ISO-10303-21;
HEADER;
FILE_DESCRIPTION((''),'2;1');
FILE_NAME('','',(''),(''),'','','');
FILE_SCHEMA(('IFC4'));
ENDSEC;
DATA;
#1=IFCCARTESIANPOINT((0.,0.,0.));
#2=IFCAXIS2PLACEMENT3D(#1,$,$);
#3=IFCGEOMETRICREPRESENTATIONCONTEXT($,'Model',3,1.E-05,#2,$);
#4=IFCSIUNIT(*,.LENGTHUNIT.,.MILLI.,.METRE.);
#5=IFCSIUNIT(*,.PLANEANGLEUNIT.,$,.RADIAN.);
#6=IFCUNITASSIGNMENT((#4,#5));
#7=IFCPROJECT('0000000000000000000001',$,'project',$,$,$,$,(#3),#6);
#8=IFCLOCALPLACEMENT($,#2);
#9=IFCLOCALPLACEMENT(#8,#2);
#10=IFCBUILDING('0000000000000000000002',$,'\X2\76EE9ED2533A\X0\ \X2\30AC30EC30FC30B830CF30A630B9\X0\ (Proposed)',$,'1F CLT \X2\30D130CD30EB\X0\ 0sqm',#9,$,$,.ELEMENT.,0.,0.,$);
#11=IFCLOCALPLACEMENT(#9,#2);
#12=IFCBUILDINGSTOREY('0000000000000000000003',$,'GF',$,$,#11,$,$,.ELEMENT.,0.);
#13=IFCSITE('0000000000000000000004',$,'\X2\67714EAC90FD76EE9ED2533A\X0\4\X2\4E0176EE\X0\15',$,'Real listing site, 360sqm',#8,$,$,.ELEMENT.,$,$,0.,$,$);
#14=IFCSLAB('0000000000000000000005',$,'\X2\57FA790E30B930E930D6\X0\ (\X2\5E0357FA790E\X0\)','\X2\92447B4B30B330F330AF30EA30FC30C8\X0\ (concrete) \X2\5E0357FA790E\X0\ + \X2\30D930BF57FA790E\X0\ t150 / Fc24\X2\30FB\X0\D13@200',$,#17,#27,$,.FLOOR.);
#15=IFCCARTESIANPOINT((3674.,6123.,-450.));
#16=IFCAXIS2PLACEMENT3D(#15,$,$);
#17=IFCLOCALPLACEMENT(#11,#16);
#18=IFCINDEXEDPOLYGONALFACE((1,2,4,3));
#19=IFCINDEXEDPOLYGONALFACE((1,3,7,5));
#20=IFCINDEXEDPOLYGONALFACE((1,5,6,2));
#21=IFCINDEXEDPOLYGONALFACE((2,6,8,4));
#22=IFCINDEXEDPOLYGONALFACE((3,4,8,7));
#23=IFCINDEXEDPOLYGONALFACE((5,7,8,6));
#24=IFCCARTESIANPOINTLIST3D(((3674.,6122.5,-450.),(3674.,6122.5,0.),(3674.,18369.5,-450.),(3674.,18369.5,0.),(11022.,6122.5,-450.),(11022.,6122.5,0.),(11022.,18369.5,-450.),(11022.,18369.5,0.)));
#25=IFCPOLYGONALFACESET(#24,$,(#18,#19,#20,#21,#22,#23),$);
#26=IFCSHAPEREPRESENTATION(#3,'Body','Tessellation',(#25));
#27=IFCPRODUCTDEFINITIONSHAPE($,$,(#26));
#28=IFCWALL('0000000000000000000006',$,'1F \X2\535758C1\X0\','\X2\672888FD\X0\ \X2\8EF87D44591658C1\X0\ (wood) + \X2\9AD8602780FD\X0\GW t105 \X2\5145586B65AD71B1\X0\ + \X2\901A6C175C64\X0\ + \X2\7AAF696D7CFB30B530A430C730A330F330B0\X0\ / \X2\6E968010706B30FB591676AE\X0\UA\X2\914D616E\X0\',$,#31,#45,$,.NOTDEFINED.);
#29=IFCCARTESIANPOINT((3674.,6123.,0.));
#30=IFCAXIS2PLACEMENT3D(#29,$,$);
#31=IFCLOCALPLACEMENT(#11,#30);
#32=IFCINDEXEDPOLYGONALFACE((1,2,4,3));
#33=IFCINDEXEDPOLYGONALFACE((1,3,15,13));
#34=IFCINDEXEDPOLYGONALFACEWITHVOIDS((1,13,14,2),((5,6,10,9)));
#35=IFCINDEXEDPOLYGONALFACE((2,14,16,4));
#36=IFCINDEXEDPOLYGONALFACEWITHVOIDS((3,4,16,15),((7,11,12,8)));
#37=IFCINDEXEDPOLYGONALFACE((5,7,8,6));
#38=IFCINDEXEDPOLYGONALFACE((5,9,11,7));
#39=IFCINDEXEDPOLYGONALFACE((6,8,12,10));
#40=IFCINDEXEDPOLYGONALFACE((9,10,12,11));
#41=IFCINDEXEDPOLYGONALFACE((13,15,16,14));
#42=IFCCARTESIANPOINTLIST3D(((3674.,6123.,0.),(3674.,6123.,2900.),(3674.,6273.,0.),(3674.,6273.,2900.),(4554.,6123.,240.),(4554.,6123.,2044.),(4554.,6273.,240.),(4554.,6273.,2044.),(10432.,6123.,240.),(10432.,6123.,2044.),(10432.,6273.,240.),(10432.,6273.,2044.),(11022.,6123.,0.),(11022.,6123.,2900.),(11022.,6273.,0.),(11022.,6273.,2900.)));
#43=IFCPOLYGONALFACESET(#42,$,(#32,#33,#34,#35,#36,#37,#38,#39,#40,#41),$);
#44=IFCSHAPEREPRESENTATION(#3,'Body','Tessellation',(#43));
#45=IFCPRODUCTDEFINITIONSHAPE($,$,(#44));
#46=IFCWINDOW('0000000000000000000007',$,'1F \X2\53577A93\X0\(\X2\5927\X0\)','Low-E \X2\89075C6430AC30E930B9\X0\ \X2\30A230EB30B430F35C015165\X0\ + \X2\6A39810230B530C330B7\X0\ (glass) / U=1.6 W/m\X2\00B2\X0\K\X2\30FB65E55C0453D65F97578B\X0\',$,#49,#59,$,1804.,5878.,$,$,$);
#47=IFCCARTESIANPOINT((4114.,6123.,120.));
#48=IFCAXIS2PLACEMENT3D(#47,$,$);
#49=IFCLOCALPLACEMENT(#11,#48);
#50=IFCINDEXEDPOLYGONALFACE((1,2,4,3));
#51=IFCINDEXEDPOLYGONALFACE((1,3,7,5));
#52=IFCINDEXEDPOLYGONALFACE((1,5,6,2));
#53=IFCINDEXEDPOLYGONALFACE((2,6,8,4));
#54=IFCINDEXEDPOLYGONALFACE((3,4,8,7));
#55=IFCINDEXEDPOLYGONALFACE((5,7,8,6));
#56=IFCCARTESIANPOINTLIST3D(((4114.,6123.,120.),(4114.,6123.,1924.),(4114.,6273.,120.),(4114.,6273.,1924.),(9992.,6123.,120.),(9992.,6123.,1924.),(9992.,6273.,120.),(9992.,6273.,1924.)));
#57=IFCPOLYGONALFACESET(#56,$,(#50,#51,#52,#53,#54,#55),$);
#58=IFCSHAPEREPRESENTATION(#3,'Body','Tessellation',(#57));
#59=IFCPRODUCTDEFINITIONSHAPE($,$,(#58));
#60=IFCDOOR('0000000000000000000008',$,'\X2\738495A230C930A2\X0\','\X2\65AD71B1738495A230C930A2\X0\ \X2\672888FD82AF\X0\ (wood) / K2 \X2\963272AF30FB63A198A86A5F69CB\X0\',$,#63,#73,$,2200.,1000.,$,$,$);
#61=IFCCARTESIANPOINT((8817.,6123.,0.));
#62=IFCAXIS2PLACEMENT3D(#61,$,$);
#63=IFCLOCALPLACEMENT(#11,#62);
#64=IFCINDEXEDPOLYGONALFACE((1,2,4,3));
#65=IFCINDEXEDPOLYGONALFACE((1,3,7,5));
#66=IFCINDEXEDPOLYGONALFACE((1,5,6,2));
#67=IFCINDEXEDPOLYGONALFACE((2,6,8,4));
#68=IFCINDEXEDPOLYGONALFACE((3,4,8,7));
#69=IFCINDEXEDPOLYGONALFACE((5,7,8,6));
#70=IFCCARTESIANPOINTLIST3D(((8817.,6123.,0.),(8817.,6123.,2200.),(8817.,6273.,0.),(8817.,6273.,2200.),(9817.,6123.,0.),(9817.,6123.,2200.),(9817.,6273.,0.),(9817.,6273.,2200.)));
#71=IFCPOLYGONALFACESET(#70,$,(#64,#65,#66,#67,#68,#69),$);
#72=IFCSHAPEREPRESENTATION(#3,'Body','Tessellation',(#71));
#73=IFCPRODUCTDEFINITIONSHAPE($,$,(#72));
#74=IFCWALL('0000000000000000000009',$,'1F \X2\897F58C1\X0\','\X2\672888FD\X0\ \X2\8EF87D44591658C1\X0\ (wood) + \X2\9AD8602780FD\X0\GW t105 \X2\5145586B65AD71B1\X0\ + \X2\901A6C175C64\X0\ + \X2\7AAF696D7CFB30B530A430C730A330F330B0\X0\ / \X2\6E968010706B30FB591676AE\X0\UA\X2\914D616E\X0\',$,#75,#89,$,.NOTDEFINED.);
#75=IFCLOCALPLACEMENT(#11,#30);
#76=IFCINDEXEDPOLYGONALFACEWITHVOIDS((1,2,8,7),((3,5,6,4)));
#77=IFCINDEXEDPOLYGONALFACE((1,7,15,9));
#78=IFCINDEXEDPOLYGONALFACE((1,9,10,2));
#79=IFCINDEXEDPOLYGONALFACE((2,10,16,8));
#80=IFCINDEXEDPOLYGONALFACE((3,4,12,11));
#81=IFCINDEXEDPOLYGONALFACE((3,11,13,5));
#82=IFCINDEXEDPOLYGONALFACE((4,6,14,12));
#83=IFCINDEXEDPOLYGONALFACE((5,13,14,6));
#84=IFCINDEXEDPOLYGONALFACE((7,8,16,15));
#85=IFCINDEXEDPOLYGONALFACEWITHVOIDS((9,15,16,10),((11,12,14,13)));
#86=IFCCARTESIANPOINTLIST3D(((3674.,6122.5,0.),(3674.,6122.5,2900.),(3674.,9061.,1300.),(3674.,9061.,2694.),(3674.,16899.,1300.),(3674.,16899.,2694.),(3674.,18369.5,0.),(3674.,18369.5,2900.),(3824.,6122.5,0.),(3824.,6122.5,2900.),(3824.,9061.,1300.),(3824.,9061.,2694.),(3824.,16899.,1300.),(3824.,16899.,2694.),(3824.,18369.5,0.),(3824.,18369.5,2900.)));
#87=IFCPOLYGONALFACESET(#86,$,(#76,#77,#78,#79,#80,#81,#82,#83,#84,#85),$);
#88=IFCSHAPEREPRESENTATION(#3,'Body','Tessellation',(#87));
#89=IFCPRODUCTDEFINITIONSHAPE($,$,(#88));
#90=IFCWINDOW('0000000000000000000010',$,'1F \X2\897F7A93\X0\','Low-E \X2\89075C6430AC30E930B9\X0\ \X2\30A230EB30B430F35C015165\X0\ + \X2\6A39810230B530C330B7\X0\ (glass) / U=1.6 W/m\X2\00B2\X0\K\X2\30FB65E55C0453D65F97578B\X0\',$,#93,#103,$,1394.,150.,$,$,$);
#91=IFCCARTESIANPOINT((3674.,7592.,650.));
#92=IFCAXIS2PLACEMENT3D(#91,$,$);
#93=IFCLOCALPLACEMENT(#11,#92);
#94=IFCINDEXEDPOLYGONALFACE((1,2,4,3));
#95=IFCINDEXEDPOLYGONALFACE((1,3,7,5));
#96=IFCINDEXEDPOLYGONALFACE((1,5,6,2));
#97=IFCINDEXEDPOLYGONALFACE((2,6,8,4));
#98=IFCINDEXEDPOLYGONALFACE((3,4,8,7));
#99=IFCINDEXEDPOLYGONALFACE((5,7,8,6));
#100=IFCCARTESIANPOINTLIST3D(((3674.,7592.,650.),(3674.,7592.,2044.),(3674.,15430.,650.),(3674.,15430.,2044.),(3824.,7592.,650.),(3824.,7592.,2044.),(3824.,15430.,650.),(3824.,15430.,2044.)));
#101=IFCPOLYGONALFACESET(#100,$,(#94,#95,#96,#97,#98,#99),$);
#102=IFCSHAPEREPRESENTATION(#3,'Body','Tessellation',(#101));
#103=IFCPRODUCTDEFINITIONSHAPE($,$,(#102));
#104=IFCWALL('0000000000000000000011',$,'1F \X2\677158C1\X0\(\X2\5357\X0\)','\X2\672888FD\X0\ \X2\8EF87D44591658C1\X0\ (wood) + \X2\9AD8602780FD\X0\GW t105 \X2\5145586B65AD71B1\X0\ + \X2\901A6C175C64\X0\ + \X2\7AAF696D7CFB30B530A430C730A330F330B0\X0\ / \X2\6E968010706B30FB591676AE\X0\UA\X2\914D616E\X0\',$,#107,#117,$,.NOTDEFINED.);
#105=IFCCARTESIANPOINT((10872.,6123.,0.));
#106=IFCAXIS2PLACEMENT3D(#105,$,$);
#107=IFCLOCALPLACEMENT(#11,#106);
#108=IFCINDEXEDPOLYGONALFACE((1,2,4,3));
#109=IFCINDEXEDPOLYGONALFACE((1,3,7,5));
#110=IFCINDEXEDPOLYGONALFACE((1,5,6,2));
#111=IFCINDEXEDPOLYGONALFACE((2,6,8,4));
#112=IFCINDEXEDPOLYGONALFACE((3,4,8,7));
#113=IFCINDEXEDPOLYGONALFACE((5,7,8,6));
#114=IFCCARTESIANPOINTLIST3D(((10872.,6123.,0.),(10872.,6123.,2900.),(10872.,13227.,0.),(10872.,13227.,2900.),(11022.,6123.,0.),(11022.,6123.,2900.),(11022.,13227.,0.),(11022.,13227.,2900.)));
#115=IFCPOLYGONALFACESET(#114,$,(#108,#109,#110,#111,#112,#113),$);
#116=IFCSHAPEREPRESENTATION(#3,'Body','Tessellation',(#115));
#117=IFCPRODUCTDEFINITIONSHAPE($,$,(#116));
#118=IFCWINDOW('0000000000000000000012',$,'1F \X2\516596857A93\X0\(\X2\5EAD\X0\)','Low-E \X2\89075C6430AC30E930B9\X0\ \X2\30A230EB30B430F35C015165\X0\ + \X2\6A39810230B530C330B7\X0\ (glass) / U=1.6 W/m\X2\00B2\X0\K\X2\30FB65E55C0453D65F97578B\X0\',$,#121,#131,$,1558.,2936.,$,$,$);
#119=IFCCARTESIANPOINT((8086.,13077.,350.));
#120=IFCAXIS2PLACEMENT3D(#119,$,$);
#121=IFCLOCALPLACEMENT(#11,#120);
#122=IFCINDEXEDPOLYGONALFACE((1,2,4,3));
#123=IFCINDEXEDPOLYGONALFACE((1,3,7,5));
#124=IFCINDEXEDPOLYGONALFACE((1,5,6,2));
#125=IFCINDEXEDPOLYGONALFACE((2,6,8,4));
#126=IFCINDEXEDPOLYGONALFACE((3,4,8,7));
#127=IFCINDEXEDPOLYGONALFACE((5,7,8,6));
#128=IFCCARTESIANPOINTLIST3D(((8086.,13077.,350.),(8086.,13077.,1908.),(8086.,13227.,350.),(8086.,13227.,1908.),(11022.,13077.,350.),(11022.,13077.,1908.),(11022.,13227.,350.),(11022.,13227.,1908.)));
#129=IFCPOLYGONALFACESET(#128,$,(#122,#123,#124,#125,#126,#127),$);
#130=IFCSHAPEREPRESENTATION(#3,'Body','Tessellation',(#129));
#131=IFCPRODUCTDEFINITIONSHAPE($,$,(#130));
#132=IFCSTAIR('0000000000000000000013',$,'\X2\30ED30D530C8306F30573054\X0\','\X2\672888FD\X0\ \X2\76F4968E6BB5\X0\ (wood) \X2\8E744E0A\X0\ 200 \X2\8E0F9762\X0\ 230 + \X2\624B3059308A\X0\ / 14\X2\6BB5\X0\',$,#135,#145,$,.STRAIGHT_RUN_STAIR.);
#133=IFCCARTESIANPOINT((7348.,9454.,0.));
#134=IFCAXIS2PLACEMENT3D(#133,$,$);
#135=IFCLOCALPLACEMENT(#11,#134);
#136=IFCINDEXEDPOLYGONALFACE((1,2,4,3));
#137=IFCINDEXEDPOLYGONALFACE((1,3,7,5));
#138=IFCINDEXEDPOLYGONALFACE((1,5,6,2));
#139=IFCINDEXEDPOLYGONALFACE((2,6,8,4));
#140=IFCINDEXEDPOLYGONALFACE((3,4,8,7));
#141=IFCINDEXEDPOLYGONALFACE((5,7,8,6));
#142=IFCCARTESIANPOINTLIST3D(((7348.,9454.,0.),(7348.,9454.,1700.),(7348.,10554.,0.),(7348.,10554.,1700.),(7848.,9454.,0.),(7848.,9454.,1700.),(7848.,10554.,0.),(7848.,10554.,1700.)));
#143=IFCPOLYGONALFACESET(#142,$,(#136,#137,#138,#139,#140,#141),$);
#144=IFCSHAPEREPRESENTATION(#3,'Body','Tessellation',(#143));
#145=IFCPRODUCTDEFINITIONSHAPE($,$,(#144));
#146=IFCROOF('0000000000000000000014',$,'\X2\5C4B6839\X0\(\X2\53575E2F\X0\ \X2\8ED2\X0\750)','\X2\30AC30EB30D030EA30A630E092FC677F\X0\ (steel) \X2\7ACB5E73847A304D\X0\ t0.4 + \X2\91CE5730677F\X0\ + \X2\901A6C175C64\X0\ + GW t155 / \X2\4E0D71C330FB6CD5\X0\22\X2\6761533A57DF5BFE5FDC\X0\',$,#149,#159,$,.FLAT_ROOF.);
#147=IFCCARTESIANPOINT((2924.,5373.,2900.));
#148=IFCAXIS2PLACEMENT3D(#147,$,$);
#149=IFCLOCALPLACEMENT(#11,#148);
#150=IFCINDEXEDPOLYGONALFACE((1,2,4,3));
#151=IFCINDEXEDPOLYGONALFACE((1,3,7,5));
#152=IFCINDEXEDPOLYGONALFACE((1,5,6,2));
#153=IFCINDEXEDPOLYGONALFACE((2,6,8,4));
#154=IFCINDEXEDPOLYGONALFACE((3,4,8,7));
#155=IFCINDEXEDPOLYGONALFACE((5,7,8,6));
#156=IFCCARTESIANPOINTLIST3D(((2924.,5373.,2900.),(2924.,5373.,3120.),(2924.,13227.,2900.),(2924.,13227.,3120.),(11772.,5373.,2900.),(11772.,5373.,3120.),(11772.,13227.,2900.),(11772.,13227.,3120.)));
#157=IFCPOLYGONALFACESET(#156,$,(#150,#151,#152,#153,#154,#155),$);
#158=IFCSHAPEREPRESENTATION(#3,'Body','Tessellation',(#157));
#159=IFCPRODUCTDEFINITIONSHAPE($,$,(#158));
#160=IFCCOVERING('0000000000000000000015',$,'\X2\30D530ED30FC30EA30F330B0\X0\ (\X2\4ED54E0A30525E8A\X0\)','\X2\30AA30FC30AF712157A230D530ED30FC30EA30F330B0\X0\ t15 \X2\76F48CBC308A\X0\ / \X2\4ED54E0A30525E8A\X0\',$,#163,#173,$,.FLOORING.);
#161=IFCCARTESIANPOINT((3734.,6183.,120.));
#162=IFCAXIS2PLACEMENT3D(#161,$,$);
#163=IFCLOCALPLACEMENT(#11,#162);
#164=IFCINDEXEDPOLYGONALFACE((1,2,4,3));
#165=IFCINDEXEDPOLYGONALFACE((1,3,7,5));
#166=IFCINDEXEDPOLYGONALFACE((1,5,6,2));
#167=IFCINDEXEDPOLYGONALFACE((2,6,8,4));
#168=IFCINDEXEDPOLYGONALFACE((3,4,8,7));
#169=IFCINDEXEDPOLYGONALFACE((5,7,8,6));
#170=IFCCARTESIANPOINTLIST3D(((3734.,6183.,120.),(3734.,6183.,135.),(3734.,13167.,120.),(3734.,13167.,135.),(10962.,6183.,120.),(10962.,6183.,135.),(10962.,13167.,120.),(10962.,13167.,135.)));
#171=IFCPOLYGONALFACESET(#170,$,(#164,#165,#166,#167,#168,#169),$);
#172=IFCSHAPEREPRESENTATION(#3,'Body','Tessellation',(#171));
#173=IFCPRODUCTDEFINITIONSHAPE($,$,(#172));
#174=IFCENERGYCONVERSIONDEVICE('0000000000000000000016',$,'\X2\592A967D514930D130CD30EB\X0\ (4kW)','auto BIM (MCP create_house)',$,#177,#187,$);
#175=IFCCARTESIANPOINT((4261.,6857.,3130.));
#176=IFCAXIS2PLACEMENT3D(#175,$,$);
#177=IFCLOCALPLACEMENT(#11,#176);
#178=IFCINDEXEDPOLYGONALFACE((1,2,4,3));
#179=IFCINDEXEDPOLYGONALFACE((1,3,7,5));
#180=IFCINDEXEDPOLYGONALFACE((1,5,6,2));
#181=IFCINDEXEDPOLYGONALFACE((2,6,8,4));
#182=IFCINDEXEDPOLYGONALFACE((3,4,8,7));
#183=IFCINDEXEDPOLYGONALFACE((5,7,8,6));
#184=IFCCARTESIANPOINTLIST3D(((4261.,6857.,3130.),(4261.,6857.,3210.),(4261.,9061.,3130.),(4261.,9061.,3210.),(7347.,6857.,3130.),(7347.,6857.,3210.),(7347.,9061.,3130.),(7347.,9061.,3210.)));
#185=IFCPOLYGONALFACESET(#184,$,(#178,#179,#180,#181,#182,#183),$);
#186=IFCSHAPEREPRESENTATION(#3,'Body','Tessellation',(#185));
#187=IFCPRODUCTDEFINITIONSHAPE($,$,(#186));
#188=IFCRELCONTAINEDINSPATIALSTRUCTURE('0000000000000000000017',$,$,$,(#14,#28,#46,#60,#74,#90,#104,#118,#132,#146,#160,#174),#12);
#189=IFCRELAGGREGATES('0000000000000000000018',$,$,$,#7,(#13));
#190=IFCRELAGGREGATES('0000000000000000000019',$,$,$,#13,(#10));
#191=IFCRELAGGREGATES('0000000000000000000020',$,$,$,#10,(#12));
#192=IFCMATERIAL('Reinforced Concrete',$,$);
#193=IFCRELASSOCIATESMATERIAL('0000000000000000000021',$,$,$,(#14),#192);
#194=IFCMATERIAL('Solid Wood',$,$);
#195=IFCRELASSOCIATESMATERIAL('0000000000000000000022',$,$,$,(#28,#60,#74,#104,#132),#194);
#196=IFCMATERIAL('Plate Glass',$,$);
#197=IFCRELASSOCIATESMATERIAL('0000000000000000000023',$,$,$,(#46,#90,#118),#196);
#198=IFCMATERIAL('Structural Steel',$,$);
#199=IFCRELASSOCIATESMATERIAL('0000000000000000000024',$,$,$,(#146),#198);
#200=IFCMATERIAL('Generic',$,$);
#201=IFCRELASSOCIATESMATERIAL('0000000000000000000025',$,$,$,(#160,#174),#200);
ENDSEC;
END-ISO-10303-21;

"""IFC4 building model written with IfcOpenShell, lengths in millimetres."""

from ifc_helpers import new_model, si_unit, frame, frame_2d, origin, place, context, project, spatial, rectangle, extrude, material, element, fill, save


model = new_model("IFC4")

# Units and contexts
model_context = context("Model", 3, precision=1e-05, world=origin())
ifc_project = project(units=[si_unit("LENGTHUNIT", "METRE", prefix="MILLI"), si_unit("PLANEANGLEUNIT", "RADIAN")], contexts=[model_context])

# Site, building, storey
site_placement = place(None, origin())
site = spatial("IfcSite", under=ifc_project, at=site_placement, Name="東京都目黒区4丁目15", ObjectType="Real listing site, 360sqm", CompositionType="ELEMENT", RefElevation=0.0)
building_placement = place(site_placement, origin())
building = spatial("IfcBuilding", under=site, at=building_placement, Name="目黒区 ガレージハウス (Proposed)", ObjectType="1F CLT パネル 0sqm", CompositionType="ELEMENT", ElevationOfRefHeight=0.0, ElevationOfTerrain=0.0)
storey_placement = place(building_placement, origin())
storey = spatial("IfcBuildingStorey", under=building, at=storey_placement, Name="GF", CompositionType="ELEMENT", Elevation=0.0)

# Slab
ifc_material_1 = material(Name="Reinforced Concrete")
slab_1_placement = place(storey_placement, frame((3674.0, 6123.0, -450.0)))
element("IfcSlab", 1, at=slab_1_placement, inside=storey, material=ifc_material_1, Name="基礎スラブ (布基礎)", Description="鉄筋コンクリート (concrete) 布基礎 + ベタ基礎 t150 / Fc24・D13@200", PredefinedType="FLOOR", context=model_context, shape_type="SweptSolid", body=[
    extrude(rectangle(XDim=7348.0, YDim=12247.0, at=frame_2d((3674.0, 6123.0))), frame((3674.0, 6123.0, -450.0)), (0.0, 0.0, 1.0), 450.0),
])
ifc_material_2 = material(Name="Solid Wood")

# Wall, openings, window, door
wall_1_placement = place(storey_placement, frame((3674.0, 6123.0, 0.0)))
wall_1 = element("IfcWall", 2, at=wall_1_placement, inside=storey, material=ifc_material_2, Name="1F 南壁", Description="木製 軸組外壁 (wood) + 高性能GW t105 充填断熱 + 通気層 + 窯業系サイディング / 準耐火・外皮UA配慮", PredefinedType="NOTDEFINED", context=model_context, shape_type="SweptSolid", body=[
    extrude(rectangle(XDim=7348.0, YDim=150.0, at=frame_2d((3674.0, 75.0))), frame((3674.0, 6123.0, 0.0)), (0.0, 0.0, 1.0), 2900.0),
])
opening_1_placement = place(storey_placement, frame((4114.0, 6123.0, 120.0)))
opening_1 = element("IfcOpeningElement", 3, at=opening_1_placement, cuts=wall_1, PredefinedType="NOTDEFINED", context=model_context, shape_type="SweptSolid", body=[
    extrude(rectangle(XDim=5878.0, YDim=150.0, at=frame_2d((2939.0, 75.0))), frame((4114.0, 6123.0, 120.0)), (0.0, 0.0, 1.0), 1804.0),
])
opening_2_placement = place(storey_placement, frame((8817.0, 6123.0, 0.0)))
opening_2 = element("IfcOpeningElement", 4, at=opening_2_placement, cuts=wall_1, PredefinedType="NOTDEFINED", context=model_context, shape_type="SweptSolid", body=[
    extrude(rectangle(XDim=1000.0, YDim=150.0, at=frame_2d((500.0, 75.0))), frame((8817.0, 6123.0, 0.0)), (0.0, 0.0, 1.0), 2200.0),
])
ifc_material_3 = material(Name="Plate Glass")
window_1_placement = place(storey_placement, frame((4114.0, 6123.0, 120.0)))
window_1 = element("IfcWindow", 5, at=window_1_placement, inside=storey, material=ifc_material_3, Name="1F 南窓(大)", Description="Low-E 複層ガラス アルゴン封入 + 樹脂サッシ (glass) / U=1.6 W/m²K・日射取得型", OverallHeight=1804.0, OverallWidth=5878.0, context=model_context, shape_type="SweptSolid", body=[
    extrude(rectangle(XDim=5878.0, YDim=150.0, at=frame_2d((2939.0, 75.0))), frame((4114.0, 6123.0, 120.0)), (0.0, 0.0, 1.0), 1804.0),
])
fill(opening_1, window_1)
door_1_placement = place(storey_placement, frame((8817.0, 6123.0, 0.0)))
door_1 = element("IfcDoor", 6, at=door_1_placement, inside=storey, material=ifc_material_2, Name="玄関ドア", Description="断熱玄関ドア 木製芯 (wood) / K2 防犯・採風機構", OverallHeight=2200.0, OverallWidth=1000.0, context=model_context, shape_type="SweptSolid", body=[
    extrude(rectangle(XDim=1000.0, YDim=150.0, at=frame_2d((500.0, 75.0))), frame((8817.0, 6123.0, 0.0)), (0.0, 0.0, 1.0), 2200.0),
])
fill(opening_2, door_1)

# Walls, openings, windows
wall_2_placement = place(storey_placement, frame((3674.0, 6123.0, 0.0)))
wall_2 = element("IfcWall", 7, at=wall_2_placement, inside=storey, material=ifc_material_2, Name="1F 西壁", Description="木製 軸組外壁 (wood) + 高性能GW t105 充填断熱 + 通気層 + 窯業系サイディング / 準耐火・外皮UA配慮", PredefinedType="NOTDEFINED", context=model_context, shape_type="SweptSolid", body=[
    extrude(rectangle(XDim=150.0, YDim=12247.0, at=frame_2d((75.0, 6123.0))), frame((3674.0, 6123.0, 0.0)), (0.0, 0.0, 1.0), 2900.0),
])
opening_3_placement = place(storey_placement, frame((3674.0, 7592.0, 650.0)))
opening_3 = element("IfcOpeningElement", 8, at=opening_3_placement, cuts=wall_2, PredefinedType="NOTDEFINED", context=model_context, shape_type="SweptSolid", body=[
    extrude(rectangle(XDim=150.0, YDim=7838.0, at=frame_2d((75.0, 3919.0))), frame((3674.0, 7592.0, 650.0)), (0.0, 0.0, 1.0), 1394.0),
])
window_2_placement = place(storey_placement, frame((3674.0, 7592.0, 650.0)))
window_2 = element("IfcWindow", 9, at=window_2_placement, inside=storey, material=ifc_material_3, Name="1F 西窓", Description="Low-E 複層ガラス アルゴン封入 + 樹脂サッシ (glass) / U=1.6 W/m²K・日射取得型", OverallHeight=1394.0, OverallWidth=150.0, context=model_context, shape_type="SweptSolid", body=[
    extrude(rectangle(XDim=150.0, YDim=7838.0, at=frame_2d((75.0, 3919.0))), frame((3674.0, 7592.0, 650.0)), (0.0, 0.0, 1.0), 1394.0),
])
fill(opening_3, window_2)
wall_3_placement = place(storey_placement, frame((10872.0, 6123.0, 0.0)))
wall_3 = element("IfcWall", 10, at=wall_3_placement, inside=storey, material=ifc_material_2, Name="1F 東壁(南)", Description="木製 軸組外壁 (wood) + 高性能GW t105 充填断熱 + 通気層 + 窯業系サイディング / 準耐火・外皮UA配慮", PredefinedType="NOTDEFINED", context=model_context, shape_type="SweptSolid", body=[
    extrude(rectangle(XDim=150.0, YDim=7104.0, at=frame_2d((75.0, 3552.0))), frame((10872.0, 6123.0, 0.0)), (0.0, 0.0, 1.0), 2900.0),
])
opening_4_placement = place(storey_placement, frame((8086.0, 13077.0, 350.0)))
opening_4 = element("IfcOpeningElement", 11, at=opening_4_placement, cuts=wall_3, PredefinedType="NOTDEFINED", context=model_context, shape_type="SweptSolid", body=[
    extrude(rectangle(XDim=2936.0, YDim=150.0, at=frame_2d((1468.0, 75.0))), frame((8086.0, 13077.0, 350.0)), (0.0, 0.0, 1.0), 1558.0),
])
window_3_placement = place(storey_placement, frame((8086.0, 13077.0, 350.0)))
window_3 = element("IfcWindow", 12, at=window_3_placement, inside=storey, material=ifc_material_3, Name="1F 入隅窓(庭)", Description="Low-E 複層ガラス アルゴン封入 + 樹脂サッシ (glass) / U=1.6 W/m²K・日射取得型", OverallHeight=1558.0, OverallWidth=2936.0, context=model_context, shape_type="SweptSolid", body=[
    extrude(rectangle(XDim=2936.0, YDim=150.0, at=frame_2d((1468.0, 75.0))), frame((8086.0, 13077.0, 350.0)), (0.0, 0.0, 1.0), 1558.0),
])
fill(opening_4, window_3)

# Stair
stair_placement = place(storey_placement, frame((7348.0, 9454.0, 0.0)))
element("IfcStair", 13, at=stair_placement, inside=storey, material=ifc_material_2, Name="ロフトはしご", Description="木製 直階段 (wood) 蹴上 200 踏面 230 + 手すり / 14段", PredefinedType="STRAIGHT_RUN_STAIR", context=model_context, shape_type="SweptSolid", body=[
    extrude(rectangle(XDim=500.0, YDim=1100.0, at=frame_2d((250.0, 550.0))), frame((7348.0, 9454.0, 0.0)), (0.0, 0.0, 1.0), 1700.0),
])

# Roof
ifc_material_4 = material(Name="Structural Steel")
roof_placement = place(storey_placement, frame((2924.0, 5373.0, 2900.0)))
element("IfcRoof", 14, at=roof_placement, inside=storey, material=ifc_material_4, Name="屋根(南帯 軒750)", Description="ガルバリウム鋼板 (steel) 立平葺き t0.4 + 野地板 + 通気層 + GW t155 / 不燃・法22条区域対応", PredefinedType="FLAT_ROOF", context=model_context, shape_type="SweptSolid", body=[
    extrude(rectangle(XDim=8848.0, YDim=7854.0, at=frame_2d((4424.0, 3927.0))), frame((2924.0, 5373.0, 2900.0)), (0.0, 0.0, 1.0), 220.0),
])

# Covering
ifc_material_5 = material(Name="Generic")
covering_placement = place(storey_placement, frame((3734.0, 6183.0, 120.0)))
element("IfcCovering", 15, at=covering_placement, inside=storey, material=ifc_material_5, Name="フローリング (仕上げ床)", Description="オーク無垢フローリング t15 直貼り / 仕上げ床", PredefinedType="FLOORING", context=model_context, shape_type="SweptSolid", body=[
    extrude(rectangle(XDim=7228.0, YDim=6984.0, at=frame_2d((3614.0, 3492.0))), frame((3734.0, 6183.0, 120.0)), (0.0, 0.0, 1.0), 15.0),
])

# Energy conversion device
energy_conversion_device_placement = place(storey_placement, frame((4261.0, 6857.0, 3130.0)))
element("IfcEnergyConversionDevice", 16, at=energy_conversion_device_placement, inside=storey, material=ifc_material_5, Name="太陽光パネル (4kW)", Description="auto BIM (MCP create_house)", context=model_context, shape_type="SweptSolid", body=[
    extrude(rectangle(XDim=3086.0, YDim=2204.0, at=frame_2d((1543.0, 1102.0))), frame((4261.0, 6857.0, 3130.0)), (0.0, 0.0, 1.0), 80.0),
])

save(model, "model.ifc")
